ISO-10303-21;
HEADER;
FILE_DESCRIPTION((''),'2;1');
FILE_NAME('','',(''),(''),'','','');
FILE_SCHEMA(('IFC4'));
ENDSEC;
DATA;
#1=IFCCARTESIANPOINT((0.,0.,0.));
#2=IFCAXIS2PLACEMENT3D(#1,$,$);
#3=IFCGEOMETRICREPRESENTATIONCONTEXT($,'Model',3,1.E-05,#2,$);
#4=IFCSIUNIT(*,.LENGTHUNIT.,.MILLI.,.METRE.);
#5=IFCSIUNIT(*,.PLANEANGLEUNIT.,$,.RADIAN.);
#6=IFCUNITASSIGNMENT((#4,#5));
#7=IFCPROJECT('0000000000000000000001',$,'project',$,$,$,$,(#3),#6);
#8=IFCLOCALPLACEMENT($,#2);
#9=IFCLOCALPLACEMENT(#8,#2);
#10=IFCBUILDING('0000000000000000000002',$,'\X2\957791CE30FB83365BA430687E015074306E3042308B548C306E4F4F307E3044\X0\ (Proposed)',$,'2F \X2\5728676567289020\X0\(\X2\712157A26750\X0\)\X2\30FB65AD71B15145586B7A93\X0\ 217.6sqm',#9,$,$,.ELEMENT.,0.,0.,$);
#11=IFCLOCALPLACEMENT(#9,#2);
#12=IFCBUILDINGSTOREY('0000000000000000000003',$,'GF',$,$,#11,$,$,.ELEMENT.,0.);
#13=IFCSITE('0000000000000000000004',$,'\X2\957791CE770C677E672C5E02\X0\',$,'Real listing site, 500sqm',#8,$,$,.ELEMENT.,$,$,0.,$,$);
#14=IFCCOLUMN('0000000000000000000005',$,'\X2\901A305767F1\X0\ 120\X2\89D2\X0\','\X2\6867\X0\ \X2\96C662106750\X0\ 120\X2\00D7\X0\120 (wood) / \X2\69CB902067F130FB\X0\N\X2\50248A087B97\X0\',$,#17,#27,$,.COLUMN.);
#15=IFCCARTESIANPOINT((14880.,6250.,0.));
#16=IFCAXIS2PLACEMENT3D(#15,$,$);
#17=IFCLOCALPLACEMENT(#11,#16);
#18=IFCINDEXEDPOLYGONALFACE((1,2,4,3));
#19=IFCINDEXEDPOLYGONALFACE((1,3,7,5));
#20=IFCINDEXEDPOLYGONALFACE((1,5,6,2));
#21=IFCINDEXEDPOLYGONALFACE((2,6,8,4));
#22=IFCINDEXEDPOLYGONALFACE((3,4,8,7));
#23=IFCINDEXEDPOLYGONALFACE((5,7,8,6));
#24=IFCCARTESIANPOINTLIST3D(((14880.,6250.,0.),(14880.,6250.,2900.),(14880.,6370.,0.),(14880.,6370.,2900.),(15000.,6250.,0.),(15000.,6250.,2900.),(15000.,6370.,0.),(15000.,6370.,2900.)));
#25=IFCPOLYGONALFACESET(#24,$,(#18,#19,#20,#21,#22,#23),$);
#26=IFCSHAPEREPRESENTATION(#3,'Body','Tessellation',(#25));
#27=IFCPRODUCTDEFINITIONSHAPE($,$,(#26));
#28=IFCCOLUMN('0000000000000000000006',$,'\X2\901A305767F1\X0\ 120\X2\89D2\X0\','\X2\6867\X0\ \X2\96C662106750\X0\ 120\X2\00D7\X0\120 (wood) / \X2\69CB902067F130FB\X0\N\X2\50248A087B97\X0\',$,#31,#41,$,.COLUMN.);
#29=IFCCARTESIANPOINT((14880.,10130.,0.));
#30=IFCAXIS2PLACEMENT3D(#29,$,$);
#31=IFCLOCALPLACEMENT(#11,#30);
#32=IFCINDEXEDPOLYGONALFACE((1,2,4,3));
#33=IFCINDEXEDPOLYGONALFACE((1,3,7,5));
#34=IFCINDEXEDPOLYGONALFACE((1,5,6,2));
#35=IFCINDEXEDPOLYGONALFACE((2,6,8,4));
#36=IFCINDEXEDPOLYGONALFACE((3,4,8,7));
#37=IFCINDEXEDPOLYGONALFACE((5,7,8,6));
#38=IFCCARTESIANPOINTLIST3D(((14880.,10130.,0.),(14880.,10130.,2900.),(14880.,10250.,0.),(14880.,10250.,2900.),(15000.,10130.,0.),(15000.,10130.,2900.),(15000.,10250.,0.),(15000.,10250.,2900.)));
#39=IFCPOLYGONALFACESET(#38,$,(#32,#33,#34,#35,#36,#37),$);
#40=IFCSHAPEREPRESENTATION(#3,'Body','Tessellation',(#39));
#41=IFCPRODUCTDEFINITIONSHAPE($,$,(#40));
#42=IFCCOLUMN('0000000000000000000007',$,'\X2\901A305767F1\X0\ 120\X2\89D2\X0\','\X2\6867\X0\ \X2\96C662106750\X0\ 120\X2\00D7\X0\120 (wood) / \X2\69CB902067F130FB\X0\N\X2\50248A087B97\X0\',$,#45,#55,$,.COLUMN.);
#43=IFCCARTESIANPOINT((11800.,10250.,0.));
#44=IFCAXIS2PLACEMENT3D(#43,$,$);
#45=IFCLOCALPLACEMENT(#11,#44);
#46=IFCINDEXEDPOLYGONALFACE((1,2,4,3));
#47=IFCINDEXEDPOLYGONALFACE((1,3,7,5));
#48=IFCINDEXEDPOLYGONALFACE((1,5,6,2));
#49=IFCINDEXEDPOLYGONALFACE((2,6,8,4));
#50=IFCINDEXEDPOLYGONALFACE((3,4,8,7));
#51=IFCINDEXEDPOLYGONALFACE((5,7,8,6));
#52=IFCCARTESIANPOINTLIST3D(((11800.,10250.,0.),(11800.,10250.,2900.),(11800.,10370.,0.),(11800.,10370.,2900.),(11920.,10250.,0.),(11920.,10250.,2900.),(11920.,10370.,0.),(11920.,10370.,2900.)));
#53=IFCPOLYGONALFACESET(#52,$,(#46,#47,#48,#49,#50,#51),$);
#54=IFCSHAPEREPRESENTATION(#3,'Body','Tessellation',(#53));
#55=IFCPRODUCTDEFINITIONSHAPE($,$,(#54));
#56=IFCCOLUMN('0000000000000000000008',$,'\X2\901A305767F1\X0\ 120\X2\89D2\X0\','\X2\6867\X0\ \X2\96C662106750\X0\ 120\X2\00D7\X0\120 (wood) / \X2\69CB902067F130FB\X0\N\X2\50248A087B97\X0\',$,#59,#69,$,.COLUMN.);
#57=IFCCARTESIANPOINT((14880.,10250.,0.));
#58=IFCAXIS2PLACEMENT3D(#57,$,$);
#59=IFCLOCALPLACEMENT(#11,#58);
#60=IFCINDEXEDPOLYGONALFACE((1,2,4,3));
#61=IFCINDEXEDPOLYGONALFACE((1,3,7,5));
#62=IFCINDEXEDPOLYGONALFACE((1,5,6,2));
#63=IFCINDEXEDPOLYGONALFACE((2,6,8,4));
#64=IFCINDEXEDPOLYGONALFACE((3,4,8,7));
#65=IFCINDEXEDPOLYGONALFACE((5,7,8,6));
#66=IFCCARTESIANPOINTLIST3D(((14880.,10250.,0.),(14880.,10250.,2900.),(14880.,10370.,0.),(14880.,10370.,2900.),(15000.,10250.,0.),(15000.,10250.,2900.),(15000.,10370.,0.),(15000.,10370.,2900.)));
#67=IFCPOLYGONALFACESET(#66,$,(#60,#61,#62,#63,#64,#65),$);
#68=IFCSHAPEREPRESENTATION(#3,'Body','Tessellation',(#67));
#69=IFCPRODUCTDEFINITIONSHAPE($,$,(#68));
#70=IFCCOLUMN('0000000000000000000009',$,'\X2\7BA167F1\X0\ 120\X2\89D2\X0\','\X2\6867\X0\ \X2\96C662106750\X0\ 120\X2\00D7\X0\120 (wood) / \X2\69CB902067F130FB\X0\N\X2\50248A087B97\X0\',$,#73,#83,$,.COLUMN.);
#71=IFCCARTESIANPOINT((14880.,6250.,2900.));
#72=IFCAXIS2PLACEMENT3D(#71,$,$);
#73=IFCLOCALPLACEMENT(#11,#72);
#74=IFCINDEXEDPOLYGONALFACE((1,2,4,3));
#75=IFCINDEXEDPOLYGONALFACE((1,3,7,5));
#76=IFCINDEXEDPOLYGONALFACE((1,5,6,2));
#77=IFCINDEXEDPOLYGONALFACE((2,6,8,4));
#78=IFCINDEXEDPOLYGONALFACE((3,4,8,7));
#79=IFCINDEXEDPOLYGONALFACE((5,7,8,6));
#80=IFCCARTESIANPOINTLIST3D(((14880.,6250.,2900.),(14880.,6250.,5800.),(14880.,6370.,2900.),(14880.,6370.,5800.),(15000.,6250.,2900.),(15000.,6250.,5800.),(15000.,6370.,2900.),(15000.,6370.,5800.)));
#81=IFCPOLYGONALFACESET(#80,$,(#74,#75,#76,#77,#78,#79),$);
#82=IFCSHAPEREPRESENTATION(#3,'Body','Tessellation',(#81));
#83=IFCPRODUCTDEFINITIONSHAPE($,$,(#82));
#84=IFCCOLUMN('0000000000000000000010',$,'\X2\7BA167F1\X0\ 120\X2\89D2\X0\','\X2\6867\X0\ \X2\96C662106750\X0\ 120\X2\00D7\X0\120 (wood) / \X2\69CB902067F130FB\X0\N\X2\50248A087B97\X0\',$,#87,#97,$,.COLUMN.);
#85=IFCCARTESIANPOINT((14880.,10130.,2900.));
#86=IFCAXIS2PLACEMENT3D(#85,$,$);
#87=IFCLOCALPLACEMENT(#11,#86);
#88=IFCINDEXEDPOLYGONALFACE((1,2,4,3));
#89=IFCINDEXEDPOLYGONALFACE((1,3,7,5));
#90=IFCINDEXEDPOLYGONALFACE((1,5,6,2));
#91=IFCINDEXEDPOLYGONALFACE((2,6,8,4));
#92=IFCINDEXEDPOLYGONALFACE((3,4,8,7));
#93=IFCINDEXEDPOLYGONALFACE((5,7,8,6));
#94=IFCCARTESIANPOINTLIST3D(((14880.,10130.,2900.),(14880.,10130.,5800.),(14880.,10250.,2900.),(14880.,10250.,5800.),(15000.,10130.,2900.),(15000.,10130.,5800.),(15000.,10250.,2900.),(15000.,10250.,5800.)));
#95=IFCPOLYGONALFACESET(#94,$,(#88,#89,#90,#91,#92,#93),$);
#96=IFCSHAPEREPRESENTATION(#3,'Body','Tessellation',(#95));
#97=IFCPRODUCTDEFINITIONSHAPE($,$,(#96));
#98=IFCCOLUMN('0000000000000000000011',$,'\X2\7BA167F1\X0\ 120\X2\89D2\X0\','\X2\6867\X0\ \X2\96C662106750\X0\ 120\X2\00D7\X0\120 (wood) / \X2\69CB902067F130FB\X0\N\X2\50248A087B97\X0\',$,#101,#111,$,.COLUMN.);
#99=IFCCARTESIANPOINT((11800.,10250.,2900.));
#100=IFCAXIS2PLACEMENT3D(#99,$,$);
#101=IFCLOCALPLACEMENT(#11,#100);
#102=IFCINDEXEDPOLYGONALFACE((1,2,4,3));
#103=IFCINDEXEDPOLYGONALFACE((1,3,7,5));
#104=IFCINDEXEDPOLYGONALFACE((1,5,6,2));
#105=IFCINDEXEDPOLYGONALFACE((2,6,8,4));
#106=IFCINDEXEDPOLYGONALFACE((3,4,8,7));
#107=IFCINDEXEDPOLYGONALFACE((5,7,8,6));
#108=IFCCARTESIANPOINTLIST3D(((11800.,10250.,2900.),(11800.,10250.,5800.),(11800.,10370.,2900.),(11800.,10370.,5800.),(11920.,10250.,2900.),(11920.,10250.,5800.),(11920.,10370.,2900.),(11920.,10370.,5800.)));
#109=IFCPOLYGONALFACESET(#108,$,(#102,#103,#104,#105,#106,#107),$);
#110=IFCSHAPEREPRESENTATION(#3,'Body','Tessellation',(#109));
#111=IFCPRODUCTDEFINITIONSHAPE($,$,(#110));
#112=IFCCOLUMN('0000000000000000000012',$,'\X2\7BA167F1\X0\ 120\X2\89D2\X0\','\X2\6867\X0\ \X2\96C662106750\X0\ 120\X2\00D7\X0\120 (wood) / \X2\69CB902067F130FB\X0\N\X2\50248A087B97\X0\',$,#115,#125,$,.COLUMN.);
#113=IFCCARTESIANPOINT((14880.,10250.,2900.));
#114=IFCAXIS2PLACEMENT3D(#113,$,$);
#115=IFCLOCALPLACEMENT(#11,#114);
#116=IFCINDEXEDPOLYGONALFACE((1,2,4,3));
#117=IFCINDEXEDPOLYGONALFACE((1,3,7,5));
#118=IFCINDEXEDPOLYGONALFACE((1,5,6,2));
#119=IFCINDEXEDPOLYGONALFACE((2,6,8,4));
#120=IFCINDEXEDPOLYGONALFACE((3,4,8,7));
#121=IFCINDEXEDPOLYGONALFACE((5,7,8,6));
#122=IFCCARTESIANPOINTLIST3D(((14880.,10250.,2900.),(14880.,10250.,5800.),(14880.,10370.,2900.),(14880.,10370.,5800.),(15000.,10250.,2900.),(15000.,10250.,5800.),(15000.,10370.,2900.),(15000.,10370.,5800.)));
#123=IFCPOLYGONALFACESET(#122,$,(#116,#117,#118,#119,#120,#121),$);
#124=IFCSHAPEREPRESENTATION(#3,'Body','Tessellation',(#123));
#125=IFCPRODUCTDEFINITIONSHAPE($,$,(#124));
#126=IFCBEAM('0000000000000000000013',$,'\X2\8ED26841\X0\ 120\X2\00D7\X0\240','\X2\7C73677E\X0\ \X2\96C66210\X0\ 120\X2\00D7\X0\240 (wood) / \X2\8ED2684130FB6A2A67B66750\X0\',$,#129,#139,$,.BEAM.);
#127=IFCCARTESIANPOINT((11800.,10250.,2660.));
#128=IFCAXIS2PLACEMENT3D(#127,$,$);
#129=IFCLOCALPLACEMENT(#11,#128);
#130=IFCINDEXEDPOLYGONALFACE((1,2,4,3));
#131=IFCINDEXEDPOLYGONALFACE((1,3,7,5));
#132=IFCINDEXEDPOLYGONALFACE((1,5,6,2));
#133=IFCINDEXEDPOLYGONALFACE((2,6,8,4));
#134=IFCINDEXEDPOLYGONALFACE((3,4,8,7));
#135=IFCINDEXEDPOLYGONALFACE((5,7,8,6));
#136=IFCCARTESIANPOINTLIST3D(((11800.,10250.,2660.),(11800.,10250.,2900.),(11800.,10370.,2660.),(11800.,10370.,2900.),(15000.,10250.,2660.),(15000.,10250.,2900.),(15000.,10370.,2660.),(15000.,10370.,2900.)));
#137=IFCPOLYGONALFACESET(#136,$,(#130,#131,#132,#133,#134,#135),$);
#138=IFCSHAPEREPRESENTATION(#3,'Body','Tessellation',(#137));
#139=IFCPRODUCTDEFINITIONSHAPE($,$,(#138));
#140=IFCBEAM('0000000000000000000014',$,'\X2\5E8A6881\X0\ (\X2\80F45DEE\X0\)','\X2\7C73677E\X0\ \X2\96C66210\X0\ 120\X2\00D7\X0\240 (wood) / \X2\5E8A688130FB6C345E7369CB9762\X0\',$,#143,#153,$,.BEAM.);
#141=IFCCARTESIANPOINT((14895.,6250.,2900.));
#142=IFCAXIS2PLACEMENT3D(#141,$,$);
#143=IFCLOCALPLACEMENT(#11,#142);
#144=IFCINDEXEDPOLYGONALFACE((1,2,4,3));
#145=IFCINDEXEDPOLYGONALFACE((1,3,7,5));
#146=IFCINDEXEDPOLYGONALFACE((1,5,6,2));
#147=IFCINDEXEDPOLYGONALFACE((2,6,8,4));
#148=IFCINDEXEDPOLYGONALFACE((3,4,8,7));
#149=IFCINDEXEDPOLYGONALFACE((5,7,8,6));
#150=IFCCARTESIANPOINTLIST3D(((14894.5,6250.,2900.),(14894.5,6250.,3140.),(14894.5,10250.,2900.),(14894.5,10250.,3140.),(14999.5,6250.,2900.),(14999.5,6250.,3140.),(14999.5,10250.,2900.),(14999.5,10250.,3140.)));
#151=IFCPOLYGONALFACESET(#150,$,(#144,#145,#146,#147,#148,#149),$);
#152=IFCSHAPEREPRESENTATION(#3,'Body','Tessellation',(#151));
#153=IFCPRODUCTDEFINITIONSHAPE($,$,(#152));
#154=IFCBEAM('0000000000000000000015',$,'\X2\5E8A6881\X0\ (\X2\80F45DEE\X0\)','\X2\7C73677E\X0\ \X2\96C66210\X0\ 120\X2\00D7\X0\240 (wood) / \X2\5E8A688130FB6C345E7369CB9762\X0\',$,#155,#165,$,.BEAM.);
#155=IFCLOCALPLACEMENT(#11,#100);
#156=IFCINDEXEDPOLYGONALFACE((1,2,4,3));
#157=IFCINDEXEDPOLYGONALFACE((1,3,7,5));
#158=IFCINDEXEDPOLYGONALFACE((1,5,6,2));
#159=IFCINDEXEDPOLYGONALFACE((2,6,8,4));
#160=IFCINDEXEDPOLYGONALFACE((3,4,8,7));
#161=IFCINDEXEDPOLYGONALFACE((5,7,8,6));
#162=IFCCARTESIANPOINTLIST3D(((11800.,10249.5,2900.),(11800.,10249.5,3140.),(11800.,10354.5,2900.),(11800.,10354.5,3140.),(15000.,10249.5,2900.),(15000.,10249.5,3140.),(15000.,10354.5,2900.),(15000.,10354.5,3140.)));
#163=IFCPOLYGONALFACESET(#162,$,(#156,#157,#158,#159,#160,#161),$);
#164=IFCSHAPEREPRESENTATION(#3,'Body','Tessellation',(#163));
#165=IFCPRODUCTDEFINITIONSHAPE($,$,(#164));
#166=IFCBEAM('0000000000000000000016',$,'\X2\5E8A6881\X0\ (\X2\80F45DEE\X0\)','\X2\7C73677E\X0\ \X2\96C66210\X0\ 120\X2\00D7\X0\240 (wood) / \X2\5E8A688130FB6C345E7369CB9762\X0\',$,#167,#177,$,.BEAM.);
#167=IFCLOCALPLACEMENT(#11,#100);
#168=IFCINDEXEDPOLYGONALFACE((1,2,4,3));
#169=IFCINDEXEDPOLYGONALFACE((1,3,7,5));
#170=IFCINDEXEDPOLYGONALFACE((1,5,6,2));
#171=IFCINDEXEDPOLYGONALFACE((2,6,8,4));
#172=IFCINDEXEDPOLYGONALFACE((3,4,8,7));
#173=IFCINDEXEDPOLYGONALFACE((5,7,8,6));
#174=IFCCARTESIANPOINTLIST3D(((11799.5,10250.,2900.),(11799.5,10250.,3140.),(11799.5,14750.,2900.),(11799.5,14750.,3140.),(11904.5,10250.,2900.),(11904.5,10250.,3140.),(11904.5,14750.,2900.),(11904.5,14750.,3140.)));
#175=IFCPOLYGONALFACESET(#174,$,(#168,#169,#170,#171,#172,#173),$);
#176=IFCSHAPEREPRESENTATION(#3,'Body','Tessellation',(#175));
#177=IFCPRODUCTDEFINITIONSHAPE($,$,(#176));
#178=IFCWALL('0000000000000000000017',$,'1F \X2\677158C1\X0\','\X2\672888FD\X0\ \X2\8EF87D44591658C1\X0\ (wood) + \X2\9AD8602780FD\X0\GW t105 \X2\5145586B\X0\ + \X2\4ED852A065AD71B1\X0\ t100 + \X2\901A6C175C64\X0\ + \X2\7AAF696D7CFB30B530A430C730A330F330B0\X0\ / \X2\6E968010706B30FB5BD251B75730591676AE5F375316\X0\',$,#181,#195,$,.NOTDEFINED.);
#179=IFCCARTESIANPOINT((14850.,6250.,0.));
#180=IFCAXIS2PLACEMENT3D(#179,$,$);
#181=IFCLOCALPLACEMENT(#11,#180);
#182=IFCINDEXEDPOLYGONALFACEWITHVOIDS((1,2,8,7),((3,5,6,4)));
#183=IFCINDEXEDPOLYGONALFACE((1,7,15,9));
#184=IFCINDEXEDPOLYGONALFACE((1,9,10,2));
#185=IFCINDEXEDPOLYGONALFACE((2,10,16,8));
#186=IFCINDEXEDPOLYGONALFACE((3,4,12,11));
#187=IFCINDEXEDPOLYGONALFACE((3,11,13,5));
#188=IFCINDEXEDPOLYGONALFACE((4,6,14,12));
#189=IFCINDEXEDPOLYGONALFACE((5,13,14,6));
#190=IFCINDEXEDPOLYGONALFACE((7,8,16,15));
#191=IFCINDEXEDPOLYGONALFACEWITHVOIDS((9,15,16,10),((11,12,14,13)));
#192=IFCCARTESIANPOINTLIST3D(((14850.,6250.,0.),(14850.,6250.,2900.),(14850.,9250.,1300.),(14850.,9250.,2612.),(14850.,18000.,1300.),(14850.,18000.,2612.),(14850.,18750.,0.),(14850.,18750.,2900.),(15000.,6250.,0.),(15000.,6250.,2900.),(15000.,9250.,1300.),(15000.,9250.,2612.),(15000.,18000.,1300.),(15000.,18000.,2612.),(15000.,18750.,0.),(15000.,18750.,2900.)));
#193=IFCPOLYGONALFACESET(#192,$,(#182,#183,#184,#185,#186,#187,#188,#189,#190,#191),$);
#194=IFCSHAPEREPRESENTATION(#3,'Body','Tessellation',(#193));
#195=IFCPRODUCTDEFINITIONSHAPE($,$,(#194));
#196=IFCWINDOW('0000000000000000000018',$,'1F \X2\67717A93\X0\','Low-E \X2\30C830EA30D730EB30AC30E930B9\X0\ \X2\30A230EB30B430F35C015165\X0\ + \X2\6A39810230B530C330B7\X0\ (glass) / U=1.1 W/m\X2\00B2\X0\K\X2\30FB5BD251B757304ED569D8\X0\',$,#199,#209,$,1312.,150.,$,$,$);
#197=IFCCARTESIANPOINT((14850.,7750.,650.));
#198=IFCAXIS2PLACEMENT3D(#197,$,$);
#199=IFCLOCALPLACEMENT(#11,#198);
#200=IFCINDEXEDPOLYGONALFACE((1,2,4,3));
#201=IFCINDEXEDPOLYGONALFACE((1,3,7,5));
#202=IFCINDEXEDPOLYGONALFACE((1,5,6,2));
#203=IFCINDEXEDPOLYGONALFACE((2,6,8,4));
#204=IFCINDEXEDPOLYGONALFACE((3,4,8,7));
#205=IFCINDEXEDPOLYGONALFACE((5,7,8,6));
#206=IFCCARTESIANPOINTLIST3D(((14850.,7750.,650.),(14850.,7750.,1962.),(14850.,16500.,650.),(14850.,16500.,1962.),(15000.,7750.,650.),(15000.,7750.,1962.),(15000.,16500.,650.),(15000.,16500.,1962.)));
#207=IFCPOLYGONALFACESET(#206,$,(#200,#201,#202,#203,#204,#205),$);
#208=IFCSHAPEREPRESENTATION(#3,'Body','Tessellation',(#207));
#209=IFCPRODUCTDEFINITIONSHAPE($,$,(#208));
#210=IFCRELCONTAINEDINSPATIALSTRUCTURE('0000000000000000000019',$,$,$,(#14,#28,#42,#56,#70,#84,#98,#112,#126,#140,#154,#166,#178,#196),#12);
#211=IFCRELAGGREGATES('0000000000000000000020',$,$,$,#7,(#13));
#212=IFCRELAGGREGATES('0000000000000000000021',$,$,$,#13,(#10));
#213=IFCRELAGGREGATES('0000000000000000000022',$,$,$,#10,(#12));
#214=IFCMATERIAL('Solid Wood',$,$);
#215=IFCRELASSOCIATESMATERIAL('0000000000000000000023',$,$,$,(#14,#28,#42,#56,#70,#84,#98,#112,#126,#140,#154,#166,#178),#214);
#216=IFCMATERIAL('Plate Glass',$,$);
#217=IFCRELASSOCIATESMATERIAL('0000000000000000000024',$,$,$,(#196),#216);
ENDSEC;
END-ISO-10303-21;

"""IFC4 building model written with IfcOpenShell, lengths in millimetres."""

from ifc_helpers import new_model, si_unit, frame, frame_2d, origin, place, context, project, spatial, rectangle, extrude, material, element, fill, save


model = new_model("IFC4")

# Units and contexts
model_context = context("Model", 3, precision=1e-05, world=origin())
ifc_project = project(units=[si_unit("LENGTHUNIT", "METRE", prefix="MILLI"), si_unit("PLANEANGLEUNIT", "RADIAN")], contexts=[model_context])

# Site, building, storey
site_placement = place(None, origin())
site = spatial("IfcSite", under=ifc_project, at=site_placement, Name="長野県松本市", ObjectType="Real listing site, 500sqm", CompositionType="ELEMENT", RefElevation=0.0)
building_placement = place(site_placement, origin())
building = spatial("IfcBuilding", under=site, at=building_placement, Name="長野・茶室と縁側のある和の住まい (Proposed)", ObjectType="2F 在来木造(無垢材)・断熱充填窓 217.6sqm", CompositionType="ELEMENT", ElevationOfRefHeight=0.0, ElevationOfTerrain=0.0)
storey_placement = place(building_placement, origin())
storey = spatial("IfcBuildingStorey", under=building, at=storey_placement, Name="GF", CompositionType="ELEMENT", Elevation=0.0)

# Columns
ifc_material_1 = material(Name="Solid Wood")
column_1_placement = place(storey_placement, frame((14880.0, 6250.0, 0.0)))
element("IfcColumn", 1, at=column_1_placement, inside=storey, material=ifc_material_1, Name="通し柱 120角", Description="桧 集成材 120×120 (wood) / 構造柱・N値計算", PredefinedType="COLUMN", context=model_context, shape_type="SweptSolid", body=[
    extrude(rectangle(XDim=120.0, YDim=120.0, at=frame_2d((60.0, 60.0))), frame((14880.0, 6250.0, 0.0)), (0.0, 0.0, 1.0), 2900.0),
])
column_2_placement = place(storey_placement, frame((14880.0, 10130.0, 0.0)))
element("IfcColumn", 2, at=column_2_placement, inside=storey, material=ifc_material_1, Name="通し柱 120角", Description="桧 集成材 120×120 (wood) / 構造柱・N値計算", PredefinedType="COLUMN", context=model_context, shape_type="SweptSolid", body=[
    extrude(rectangle(XDim=120.0, YDim=120.0, at=frame_2d((60.0, 60.0))), frame((14880.0, 10130.0, 0.0)), (0.0, 0.0, 1.0), 2900.0),
])
column_3_placement = place(storey_placement, frame((11800.0, 10250.0, 0.0)))
element("IfcColumn", 3, at=column_3_placement, inside=storey, material=ifc_material_1, Name="通し柱 120角", Description="桧 集成材 120×120 (wood) / 構造柱・N値計算", PredefinedType="COLUMN", context=model_context, shape_type="SweptSolid", body=[
    extrude(rectangle(XDim=120.0, YDim=120.0, at=frame_2d((60.0, 60.0))), frame((11800.0, 10250.0, 0.0)), (0.0, 0.0, 1.0), 2900.0),
])
column_4_placement = place(storey_placement, frame((14880.0, 10250.0, 0.0)))
element("IfcColumn", 4, at=column_4_placement, inside=storey, material=ifc_material_1, Name="通し柱 120角", Description="桧 集成材 120×120 (wood) / 構造柱・N値計算", PredefinedType="COLUMN", context=model_context, shape_type="SweptSolid", body=[
    extrude(rectangle(XDim=120.0, YDim=120.0, at=frame_2d((60.0, 60.0))), frame((14880.0, 10250.0, 0.0)), (0.0, 0.0, 1.0), 2900.0),
])
column_5_placement = place(storey_placement, frame((14880.0, 6250.0, 2900.0)))
element("IfcColumn", 5, at=column_5_placement, inside=storey, material=ifc_material_1, Name="管柱 120角", Description="桧 集成材 120×120 (wood) / 構造柱・N値計算", PredefinedType="COLUMN", context=model_context, shape_type="SweptSolid", body=[
    extrude(rectangle(XDim=120.0, YDim=120.0, at=frame_2d((60.0, 60.0))), frame((14880.0, 6250.0, 2900.0)), (0.0, 0.0, 1.0), 2900.0),
])
column_6_placement = place(storey_placement, frame((14880.0, 10130.0, 2900.0)))
element("IfcColumn", 6, at=column_6_placement, inside=storey, material=ifc_material_1, Name="管柱 120角", Description="桧 集成材 120×120 (wood) / 構造柱・N値計算", PredefinedType="COLUMN", context=model_context, shape_type="SweptSolid", body=[
    extrude(rectangle(XDim=120.0, YDim=120.0, at=frame_2d((60.0, 60.0))), frame((14880.0, 10130.0, 2900.0)), (0.0, 0.0, 1.0), 2900.0),
])
column_7_placement = place(storey_placement, frame((11800.0, 10250.0, 2900.0)))
element("IfcColumn", 7, at=column_7_placement, inside=storey, material=ifc_material_1, Name="管柱 120角", Description="桧 集成材 120×120 (wood) / 構造柱・N値計算", PredefinedType="COLUMN", context=model_context, shape_type="SweptSolid", body=[
    extrude(rectangle(XDim=120.0, YDim=120.0, at=frame_2d((60.0, 60.0))), frame((11800.0, 10250.0, 2900.0)), (0.0, 0.0, 1.0), 2900.0),
])
column_8_placement = place(storey_placement, frame((14880.0, 10250.0, 2900.0)))
element("IfcColumn", 8, at=column_8_placement, inside=storey, material=ifc_material_1, Name="管柱 120角", Description="桧 集成材 120×120 (wood) / 構造柱・N値計算", PredefinedType="COLUMN", context=model_context, shape_type="SweptSolid", body=[
    extrude(rectangle(XDim=120.0, YDim=120.0, at=frame_2d((60.0, 60.0))), frame((14880.0, 10250.0, 2900.0)), (0.0, 0.0, 1.0), 2900.0),
])

# Beams
beam_1_placement = place(storey_placement, frame((11800.0, 10250.0, 2660.0)))
element("IfcBeam", 9, at=beam_1_placement, inside=storey, material=ifc_material_1, Name="軒桁 120×240", Description="米松 集成 120×240 (wood) / 軒桁・横架材", PredefinedType="BEAM", context=model_context, shape_type="SweptSolid", body=[
    extrude(rectangle(XDim=3200.0, YDim=120.0, at=frame_2d((1600.0, 60.0))), frame((11800.0, 10250.0, 2660.0)), (0.0, 0.0, 1.0), 240.0),
])
beam_2_placement = place(storey_placement, frame((14895.0, 6250.0, 2900.0)))
element("IfcBeam", 10, at=beam_2_placement, inside=storey, material=ifc_material_1, Name="床梁 (胴差)", Description="米松 集成 120×240 (wood) / 床梁・水平構面", PredefinedType="BEAM", context=model_context, shape_type="SweptSolid", body=[
    extrude(rectangle(XDim=105.0, YDim=4000.0, at=frame_2d((52.0, 2000.0))), frame((14895.0, 6250.0, 2900.0)), (0.0, 0.0, 1.0), 240.0),
])
beam_3_placement = place(storey_placement, frame((11800.0, 10250.0, 2900.0)))
element("IfcBeam", 11, at=beam_3_placement, inside=storey, material=ifc_material_1, Name="床梁 (胴差)", Description="米松 集成 120×240 (wood) / 床梁・水平構面", PredefinedType="BEAM", context=model_context, shape_type="SweptSolid", body=[
    extrude(rectangle(XDim=3200.0, YDim=105.0, at=frame_2d((1600.0, 52.0))), frame((11800.0, 10250.0, 2900.0)), (0.0, 0.0, 1.0), 240.0),
])
beam_4_placement = place(storey_placement, frame((11800.0, 10250.0, 2900.0)))
element("IfcBeam", 12, at=beam_4_placement, inside=storey, material=ifc_material_1, Name="床梁 (胴差)", Description="米松 集成 120×240 (wood) / 床梁・水平構面", PredefinedType="BEAM", context=model_context, shape_type="SweptSolid", body=[
    extrude(rectangle(XDim=105.0, YDim=4500.0, at=frame_2d((52.0, 2250.0))), frame((11800.0, 10250.0, 2900.0)), (0.0, 0.0, 1.0), 240.0),
])

# Wall, opening, window
wall_1_placement = place(storey_placement, frame((14850.0, 6250.0, 0.0)))
wall_1 = element("IfcWall", 13, at=wall_1_placement, inside=storey, material=ifc_material_1, Name="1F 東壁", Description="木製 軸組外壁 (wood) + 高性能GW t105 充填 + 付加断熱 t100 + 通気層 + 窯業系サイディング / 準耐火・寒冷地外皮強化", PredefinedType="NOTDEFINED", context=model_context, shape_type="SweptSolid", body=[
    extrude(rectangle(XDim=150.0, YDim=12500.0, at=frame_2d((75.0, 6250.0))), frame((14850.0, 6250.0, 0.0)), (0.0, 0.0, 1.0), 2900.0),
])
opening_1_placement = place(storey_placement, frame((14850.0, 7750.0, 650.0)))
opening_1 = element("IfcOpeningElement", 14, at=opening_1_placement, cuts=wall_1, PredefinedType="NOTDEFINED", context=model_context, shape_type="SweptSolid", body=[
    extrude(rectangle(XDim=150.0, YDim=8750.0, at=frame_2d((75.0, 4375.0))), frame((14850.0, 7750.0, 650.0)), (0.0, 0.0, 1.0), 1312.0),
])
ifc_material_2 = material(Name="Plate Glass")
window_1_placement = place(storey_placement, frame((14850.0, 7750.0, 650.0)))
window_1 = element("IfcWindow", 15, at=window_1_placement, inside=storey, material=ifc_material_2, Name="1F 東窓", Description="Low-E トリプルガラス アルゴン封入 + 樹脂サッシ (glass) / U=1.1 W/m²K・寒冷地仕様", OverallHeight=1312.0, OverallWidth=150.0, context=model_context, shape_type="SweptSolid", body=[
    extrude(rectangle(XDim=150.0, YDim=8750.0, at=frame_2d((75.0, 4375.0))), frame((14850.0, 7750.0, 650.0)), (0.0, 0.0, 1.0), 1312.0),
])
fill(opening_1, window_1)

save(model, "model.ifc")
